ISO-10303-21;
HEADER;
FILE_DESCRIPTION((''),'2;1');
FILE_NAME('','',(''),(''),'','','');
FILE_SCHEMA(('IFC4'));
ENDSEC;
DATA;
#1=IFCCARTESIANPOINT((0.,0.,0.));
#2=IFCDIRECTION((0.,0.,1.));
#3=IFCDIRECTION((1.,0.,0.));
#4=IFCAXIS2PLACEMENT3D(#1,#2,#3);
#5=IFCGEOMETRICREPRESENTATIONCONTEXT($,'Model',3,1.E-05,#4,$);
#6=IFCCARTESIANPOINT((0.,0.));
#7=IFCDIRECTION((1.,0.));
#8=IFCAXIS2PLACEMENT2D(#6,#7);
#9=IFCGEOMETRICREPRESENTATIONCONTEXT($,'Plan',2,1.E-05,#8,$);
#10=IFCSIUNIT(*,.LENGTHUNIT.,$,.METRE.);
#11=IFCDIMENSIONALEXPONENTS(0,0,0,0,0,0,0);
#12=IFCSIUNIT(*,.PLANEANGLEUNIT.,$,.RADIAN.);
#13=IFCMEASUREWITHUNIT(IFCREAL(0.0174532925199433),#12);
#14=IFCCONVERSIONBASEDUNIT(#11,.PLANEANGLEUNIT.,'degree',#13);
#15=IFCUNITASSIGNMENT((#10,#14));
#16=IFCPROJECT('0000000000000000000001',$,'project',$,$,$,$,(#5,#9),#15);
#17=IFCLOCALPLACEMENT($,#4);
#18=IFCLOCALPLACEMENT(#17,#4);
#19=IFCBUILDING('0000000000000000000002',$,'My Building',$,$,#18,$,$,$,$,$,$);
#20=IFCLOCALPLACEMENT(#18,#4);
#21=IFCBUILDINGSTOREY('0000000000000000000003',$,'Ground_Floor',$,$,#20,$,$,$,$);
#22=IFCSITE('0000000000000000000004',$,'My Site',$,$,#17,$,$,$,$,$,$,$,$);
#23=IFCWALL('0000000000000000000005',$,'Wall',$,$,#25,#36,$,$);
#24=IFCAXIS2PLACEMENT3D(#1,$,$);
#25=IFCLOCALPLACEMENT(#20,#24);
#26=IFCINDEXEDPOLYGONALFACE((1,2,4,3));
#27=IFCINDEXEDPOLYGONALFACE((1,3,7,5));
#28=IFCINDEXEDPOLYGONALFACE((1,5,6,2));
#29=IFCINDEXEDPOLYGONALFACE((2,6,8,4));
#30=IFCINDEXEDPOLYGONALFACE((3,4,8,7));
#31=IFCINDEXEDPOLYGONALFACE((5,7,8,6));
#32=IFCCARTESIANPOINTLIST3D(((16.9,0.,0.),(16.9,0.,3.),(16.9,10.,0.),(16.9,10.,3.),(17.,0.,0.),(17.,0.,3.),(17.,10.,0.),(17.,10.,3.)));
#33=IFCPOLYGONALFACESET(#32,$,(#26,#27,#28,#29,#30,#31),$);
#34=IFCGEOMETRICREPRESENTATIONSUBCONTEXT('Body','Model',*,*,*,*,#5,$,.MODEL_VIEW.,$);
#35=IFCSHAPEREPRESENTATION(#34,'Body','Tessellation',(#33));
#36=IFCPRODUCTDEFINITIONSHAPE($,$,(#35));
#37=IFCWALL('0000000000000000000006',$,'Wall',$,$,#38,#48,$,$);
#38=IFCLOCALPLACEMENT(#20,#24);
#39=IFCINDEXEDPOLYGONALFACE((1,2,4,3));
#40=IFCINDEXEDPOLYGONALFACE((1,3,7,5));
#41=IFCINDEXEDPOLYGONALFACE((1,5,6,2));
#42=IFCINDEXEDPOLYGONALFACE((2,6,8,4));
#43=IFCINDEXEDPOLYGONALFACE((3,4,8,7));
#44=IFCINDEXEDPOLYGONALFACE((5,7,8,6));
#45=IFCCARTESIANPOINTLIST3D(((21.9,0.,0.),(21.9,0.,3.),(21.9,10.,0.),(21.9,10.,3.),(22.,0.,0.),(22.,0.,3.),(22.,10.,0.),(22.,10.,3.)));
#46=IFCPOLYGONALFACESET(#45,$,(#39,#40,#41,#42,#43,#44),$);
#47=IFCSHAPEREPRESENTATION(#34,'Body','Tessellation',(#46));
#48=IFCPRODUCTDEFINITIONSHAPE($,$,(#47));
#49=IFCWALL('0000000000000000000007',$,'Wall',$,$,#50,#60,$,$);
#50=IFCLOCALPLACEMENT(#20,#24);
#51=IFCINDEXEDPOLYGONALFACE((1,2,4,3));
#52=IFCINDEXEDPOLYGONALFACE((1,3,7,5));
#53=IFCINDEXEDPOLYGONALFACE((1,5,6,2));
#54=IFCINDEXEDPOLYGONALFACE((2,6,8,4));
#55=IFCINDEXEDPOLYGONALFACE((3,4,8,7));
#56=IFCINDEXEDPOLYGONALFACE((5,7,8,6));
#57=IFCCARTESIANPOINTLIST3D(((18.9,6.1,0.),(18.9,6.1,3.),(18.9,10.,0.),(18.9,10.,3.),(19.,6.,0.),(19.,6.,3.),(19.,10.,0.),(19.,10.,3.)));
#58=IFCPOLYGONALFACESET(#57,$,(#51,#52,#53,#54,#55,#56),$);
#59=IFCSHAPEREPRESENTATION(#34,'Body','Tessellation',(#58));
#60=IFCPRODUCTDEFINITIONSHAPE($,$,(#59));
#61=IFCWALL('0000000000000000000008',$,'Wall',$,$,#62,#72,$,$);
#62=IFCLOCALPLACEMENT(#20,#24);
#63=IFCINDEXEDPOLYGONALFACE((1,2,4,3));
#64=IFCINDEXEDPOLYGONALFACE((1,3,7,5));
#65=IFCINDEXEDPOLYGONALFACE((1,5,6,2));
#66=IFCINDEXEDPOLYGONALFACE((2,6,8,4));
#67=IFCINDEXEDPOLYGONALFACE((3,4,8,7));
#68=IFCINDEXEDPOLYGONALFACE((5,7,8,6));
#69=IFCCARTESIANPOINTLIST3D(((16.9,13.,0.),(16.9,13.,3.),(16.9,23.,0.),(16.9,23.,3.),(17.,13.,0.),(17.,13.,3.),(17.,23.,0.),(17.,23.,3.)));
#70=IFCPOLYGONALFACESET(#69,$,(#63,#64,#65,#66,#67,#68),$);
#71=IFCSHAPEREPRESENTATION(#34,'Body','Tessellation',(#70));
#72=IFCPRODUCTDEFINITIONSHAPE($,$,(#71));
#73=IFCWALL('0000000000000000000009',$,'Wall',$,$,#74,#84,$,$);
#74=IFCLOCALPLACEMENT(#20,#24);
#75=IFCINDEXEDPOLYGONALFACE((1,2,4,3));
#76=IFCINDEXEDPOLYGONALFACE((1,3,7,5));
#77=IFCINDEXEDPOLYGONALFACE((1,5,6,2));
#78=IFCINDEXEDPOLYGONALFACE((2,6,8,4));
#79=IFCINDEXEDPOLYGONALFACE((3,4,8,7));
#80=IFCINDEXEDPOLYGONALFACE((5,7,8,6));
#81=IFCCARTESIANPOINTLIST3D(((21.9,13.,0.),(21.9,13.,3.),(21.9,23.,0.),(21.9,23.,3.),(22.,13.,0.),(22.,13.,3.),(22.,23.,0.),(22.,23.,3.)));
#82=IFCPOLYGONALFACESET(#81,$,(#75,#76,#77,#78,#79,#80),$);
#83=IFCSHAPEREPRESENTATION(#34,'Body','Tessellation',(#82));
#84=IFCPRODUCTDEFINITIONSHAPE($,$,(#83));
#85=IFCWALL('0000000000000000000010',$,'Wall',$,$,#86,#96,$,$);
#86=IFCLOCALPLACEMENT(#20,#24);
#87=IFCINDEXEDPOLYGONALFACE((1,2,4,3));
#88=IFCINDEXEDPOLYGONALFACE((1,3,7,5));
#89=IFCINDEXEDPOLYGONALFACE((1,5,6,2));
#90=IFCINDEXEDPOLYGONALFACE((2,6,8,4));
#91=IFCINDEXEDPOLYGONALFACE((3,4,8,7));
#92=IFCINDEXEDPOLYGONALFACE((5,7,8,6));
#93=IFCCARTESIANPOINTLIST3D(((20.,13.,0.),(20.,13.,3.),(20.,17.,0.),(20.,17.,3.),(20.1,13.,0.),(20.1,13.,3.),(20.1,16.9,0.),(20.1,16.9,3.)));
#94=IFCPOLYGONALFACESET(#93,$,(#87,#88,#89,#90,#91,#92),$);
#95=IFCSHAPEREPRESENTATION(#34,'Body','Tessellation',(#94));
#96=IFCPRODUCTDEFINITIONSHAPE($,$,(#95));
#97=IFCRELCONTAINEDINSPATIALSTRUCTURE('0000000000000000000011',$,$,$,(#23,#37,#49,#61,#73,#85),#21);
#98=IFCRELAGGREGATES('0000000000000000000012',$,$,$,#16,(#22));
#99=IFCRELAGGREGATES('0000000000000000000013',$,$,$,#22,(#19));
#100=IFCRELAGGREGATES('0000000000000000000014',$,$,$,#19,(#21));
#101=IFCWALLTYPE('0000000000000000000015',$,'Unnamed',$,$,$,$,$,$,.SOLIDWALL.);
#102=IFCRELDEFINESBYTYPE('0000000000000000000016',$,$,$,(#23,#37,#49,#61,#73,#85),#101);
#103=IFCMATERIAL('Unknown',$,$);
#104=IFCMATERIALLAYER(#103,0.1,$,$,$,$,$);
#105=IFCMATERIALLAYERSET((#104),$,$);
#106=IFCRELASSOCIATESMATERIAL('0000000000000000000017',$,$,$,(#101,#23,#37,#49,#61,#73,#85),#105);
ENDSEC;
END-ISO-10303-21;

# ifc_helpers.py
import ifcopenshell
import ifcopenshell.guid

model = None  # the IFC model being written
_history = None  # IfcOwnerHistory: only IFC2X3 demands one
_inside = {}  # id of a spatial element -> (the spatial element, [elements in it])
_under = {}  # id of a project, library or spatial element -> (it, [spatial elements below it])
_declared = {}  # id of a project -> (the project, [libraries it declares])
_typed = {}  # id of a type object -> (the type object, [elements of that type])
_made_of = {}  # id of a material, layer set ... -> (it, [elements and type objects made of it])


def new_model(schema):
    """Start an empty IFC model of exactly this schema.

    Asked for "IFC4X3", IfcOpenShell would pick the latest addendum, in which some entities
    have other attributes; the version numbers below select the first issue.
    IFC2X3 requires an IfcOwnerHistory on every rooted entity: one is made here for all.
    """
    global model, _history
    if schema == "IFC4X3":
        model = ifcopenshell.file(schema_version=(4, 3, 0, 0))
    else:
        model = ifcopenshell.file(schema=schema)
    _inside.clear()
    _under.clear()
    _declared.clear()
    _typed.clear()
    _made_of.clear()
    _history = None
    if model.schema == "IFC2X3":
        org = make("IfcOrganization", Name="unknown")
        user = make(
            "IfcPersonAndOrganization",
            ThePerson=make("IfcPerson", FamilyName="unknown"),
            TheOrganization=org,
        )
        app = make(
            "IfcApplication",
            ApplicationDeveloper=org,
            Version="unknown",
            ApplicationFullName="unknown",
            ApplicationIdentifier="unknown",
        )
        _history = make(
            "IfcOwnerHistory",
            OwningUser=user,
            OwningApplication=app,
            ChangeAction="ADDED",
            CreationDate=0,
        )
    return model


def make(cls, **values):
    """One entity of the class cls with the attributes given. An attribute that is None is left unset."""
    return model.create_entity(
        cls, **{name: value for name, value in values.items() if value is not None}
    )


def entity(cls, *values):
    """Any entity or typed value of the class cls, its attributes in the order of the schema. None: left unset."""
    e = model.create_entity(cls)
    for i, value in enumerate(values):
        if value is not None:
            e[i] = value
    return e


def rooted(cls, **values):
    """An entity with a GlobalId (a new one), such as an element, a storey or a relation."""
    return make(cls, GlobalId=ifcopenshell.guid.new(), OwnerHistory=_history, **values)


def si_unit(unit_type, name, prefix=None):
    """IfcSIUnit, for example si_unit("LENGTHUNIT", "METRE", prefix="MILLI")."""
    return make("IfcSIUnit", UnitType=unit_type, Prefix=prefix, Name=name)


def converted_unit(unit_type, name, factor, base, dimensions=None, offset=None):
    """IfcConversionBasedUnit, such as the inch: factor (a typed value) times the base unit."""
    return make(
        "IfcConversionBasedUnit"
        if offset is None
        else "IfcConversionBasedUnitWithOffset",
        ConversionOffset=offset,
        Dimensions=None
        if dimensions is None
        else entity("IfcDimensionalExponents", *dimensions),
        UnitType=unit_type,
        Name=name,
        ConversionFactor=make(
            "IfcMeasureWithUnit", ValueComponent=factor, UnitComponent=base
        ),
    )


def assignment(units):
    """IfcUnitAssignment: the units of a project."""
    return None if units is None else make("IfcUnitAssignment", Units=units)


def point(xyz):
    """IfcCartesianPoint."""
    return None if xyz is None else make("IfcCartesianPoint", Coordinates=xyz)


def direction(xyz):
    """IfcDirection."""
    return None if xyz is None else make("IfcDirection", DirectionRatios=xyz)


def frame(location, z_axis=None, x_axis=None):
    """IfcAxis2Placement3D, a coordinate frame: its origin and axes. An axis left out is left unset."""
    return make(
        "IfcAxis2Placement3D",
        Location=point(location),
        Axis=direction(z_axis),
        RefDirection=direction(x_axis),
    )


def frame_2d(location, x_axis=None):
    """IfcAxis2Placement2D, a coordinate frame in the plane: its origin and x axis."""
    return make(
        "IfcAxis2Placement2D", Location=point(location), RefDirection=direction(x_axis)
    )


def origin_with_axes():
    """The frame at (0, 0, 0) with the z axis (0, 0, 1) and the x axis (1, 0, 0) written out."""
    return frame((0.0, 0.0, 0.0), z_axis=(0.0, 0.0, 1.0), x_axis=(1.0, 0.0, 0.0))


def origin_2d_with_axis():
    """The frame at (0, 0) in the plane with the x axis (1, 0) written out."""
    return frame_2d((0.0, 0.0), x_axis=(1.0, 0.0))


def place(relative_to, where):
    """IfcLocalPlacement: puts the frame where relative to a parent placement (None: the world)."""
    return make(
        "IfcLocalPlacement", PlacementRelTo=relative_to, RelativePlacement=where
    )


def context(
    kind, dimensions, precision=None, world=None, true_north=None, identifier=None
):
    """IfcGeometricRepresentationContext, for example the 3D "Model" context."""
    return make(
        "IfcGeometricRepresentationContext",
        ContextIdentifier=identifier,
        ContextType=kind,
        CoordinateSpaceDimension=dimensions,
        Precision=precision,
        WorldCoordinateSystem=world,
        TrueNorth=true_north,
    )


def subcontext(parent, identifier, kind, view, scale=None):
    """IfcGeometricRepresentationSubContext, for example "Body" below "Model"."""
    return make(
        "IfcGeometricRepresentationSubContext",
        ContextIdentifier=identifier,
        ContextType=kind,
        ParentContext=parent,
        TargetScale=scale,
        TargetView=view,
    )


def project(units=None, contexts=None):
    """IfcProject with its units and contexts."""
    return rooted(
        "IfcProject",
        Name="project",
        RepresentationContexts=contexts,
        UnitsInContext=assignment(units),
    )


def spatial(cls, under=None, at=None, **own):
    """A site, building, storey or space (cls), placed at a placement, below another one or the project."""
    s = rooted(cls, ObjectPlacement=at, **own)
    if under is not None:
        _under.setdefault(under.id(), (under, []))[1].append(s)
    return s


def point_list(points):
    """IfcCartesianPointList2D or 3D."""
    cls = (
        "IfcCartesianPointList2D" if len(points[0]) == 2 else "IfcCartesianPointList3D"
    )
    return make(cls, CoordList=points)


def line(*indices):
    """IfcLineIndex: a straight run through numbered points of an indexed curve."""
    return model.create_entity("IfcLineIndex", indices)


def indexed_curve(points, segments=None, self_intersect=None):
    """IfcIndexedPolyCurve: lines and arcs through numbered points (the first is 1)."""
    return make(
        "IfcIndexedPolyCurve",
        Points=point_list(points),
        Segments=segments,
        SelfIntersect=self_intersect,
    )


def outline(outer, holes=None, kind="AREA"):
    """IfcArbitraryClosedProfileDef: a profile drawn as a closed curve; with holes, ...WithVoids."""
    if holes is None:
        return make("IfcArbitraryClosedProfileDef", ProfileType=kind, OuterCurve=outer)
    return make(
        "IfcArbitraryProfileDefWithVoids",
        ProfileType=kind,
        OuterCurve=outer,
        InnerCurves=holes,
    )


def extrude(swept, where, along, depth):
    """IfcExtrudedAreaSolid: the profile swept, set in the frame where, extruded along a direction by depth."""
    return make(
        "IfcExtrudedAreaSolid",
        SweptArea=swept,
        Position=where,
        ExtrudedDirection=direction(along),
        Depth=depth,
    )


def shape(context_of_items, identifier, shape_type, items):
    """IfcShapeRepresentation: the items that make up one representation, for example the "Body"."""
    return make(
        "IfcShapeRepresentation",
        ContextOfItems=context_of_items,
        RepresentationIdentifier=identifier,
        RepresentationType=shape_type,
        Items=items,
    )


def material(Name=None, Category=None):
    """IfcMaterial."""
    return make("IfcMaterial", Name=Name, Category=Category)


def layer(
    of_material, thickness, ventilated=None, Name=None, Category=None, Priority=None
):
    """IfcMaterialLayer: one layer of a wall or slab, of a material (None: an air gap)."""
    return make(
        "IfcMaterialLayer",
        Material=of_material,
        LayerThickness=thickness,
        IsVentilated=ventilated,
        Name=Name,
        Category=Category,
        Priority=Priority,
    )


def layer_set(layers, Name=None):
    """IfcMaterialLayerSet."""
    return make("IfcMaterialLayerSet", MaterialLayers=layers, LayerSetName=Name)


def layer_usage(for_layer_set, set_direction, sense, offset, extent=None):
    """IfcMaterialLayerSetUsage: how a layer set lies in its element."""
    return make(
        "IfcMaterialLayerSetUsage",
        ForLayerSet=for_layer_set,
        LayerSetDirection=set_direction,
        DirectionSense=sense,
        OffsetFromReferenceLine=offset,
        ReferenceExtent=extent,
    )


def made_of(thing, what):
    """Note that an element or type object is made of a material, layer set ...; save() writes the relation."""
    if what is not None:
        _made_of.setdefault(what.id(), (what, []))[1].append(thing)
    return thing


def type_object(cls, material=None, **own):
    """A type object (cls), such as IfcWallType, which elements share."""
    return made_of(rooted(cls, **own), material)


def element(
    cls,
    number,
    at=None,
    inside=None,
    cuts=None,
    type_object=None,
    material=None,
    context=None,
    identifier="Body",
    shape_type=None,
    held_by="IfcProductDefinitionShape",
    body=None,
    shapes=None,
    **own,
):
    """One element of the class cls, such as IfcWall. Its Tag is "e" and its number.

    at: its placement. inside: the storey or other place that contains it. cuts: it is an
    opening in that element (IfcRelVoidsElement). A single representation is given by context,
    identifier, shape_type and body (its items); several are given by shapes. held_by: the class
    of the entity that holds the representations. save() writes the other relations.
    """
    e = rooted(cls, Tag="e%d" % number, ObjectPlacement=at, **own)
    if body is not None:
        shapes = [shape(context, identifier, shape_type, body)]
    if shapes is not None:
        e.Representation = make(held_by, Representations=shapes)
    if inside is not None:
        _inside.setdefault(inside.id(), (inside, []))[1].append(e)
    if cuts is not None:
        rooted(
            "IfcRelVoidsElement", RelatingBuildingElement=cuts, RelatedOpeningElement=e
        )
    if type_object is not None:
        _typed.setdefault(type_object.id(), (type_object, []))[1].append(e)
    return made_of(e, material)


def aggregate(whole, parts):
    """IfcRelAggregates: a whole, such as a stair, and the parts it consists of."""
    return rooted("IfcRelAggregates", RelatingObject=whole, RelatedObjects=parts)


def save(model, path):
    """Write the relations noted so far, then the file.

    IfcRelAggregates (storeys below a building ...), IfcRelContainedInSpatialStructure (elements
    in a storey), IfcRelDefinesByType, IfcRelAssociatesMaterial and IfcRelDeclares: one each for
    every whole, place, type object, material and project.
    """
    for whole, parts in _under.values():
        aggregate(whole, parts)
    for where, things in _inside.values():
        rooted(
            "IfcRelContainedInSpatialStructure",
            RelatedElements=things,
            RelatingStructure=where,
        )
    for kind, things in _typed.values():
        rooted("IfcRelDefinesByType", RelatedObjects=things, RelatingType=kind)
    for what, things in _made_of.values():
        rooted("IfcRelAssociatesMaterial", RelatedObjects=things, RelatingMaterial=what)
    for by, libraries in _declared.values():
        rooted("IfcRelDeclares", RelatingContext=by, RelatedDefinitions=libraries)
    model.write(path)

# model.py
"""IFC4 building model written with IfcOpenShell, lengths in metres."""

from ifc_helpers import new_model, entity, si_unit, converted_unit, frame, origin_with_axes, origin_2d_with_axis, place, context, subcontext, project, spatial, line, indexed_curve, outline, extrude, material, layer, layer_set, layer_usage, type_object, element, save


model = new_model("IFC4")

# Units and contexts
model_context = context("Model", 3, precision=1e-05, world=origin_with_axes())
plan_context = context("Plan", 2, precision=1e-05, world=origin_2d_with_axis())
body_context_1 = subcontext(model_context, "Body", "Model", "MODEL_VIEW")
ifc_project = project(units=[si_unit("LENGTHUNIT", "METRE"), converted_unit("PLANEANGLEUNIT", "degree", entity("IfcReal", 0.0174532925199433), si_unit("PLANEANGLEUNIT", "RADIAN"), dimensions=[0, 0, 0, 0, 0, 0, 0])], contexts=[model_context, plan_context])

# Site, building, storey
site_placement = place(None, origin_with_axes())
site = spatial("IfcSite", under=ifc_project, at=site_placement, Name="My Site")
building_placement = place(site_placement, origin_with_axes())
building = spatial("IfcBuilding", under=site, at=building_placement, Name="My Building")
storey_placement = place(building_placement, origin_with_axes())
storey = spatial("IfcBuildingStorey", under=building, at=storey_placement, Name="Ground_Floor")

# Walls
ifc_material = material(Name="Unknown")
ifc_layer = layer(ifc_material, 0.1)
ifc_layer_set = layer_set([ifc_layer])
ifc_layer_usage_1 = layer_usage(ifc_layer_set, "AXIS2", "POSITIVE", 0.0)
wall_type = type_object("IfcWallType", Name="Unnamed", PredefinedType="SOLIDWALL", material=ifc_layer_set)
wall_1_placement = place(storey_placement, frame((17.0, 0.0, 0.0), z_axis=(0.0, 0.0, 1.0), x_axis=(0.0, 1.0, 0.0)))
element("IfcWall", 1, at=wall_1_placement, inside=storey, type_object=wall_type, material=ifc_layer_usage_1, Name="Wall", context=body_context_1, shape_type="SweptSolid", body=[
    extrude(outline(indexed_curve([(0.0, 0.0), (0.0, 0.1), (10.0, 0.1), (10.0, 0.0)], segments=[line(1, 2, 3, 4, 1)])), origin_with_axes(), (0.0, 0.0, 1.0), 3.0),
])
ifc_layer_usage_2 = layer_usage(ifc_layer_set, "AXIS2", "POSITIVE", 0.0)
wall_2_placement = place(storey_placement, frame((22.0, 0.0, 0.0), z_axis=(0.0, 0.0, 1.0), x_axis=(0.0, 1.0, 0.0)))
element("IfcWall", 2, at=wall_2_placement, inside=storey, type_object=wall_type, material=ifc_layer_usage_2, Name="Wall", context=body_context_1, shape_type="SweptSolid", body=[
    extrude(outline(indexed_curve([(0.0, 0.0), (0.0, 0.1), (10.0, 0.1), (10.0, 0.0)], segments=[line(1, 2, 3, 4, 1)])), origin_with_axes(), (0.0, 0.0, 1.0), 3.0),
])
ifc_layer_usage_3 = layer_usage(ifc_layer_set, "AXIS2", "POSITIVE", 0.0)
wall_3_placement = place(storey_placement, frame((19.0, 6.0, 0.0), z_axis=(0.0, 0.0, 1.0), x_axis=(0.0, 1.0, 0.0)))
element("IfcWall", 3, at=wall_3_placement, inside=storey, type_object=wall_type, material=ifc_layer_usage_3, Name="Wall", context=body_context_1, shape_type="SweptSolid", body=[
    extrude(outline(indexed_curve([(0.0, 0.0), (0.1, 0.1), (4.0, 0.1), (4.0, 0.0)], segments=[line(1, 2, 3, 4, 1)])), origin_with_axes(), (0.0, 0.0, 1.0), 3.0),
])
ifc_layer_usage_4 = layer_usage(ifc_layer_set, "AXIS2", "POSITIVE", 0.0)
wall_4_placement = place(storey_placement, frame((17.0, 13.0, 0.0), z_axis=(0.0, 0.0, 1.0), x_axis=(0.0, 1.0, 0.0)))
element("IfcWall", 4, at=wall_4_placement, inside=storey, type_object=wall_type, material=ifc_layer_usage_4, Name="Wall", context=body_context_1, shape_type="SweptSolid", body=[
    extrude(outline(indexed_curve([(0.0, 0.0), (0.0, 0.1), (10.0, 0.1), (10.0, 0.0)], segments=[line(1, 2, 3, 4, 1)])), origin_with_axes(), (0.0, 0.0, 1.0), 3.0),
])
ifc_layer_usage_5 = layer_usage(ifc_layer_set, "AXIS2", "POSITIVE", 0.0)
wall_5_placement = place(storey_placement, frame((22.0, 13.0, 0.0), z_axis=(0.0, 0.0, 1.0), x_axis=(0.0, 1.0, 0.0)))
element("IfcWall", 5, at=wall_5_placement, inside=storey, type_object=wall_type, material=ifc_layer_usage_5, Name="Wall", context=body_context_1, shape_type="SweptSolid", body=[
    extrude(outline(indexed_curve([(0.0, 0.0), (0.0, 0.1), (10.0, 0.1), (10.0, 0.0)], segments=[line(1, 2, 3, 4, 1)])), origin_with_axes(), (0.0, 0.0, 1.0), 3.0),
])
ifc_layer_usage_6 = layer_usage(ifc_layer_set, "AXIS2", "POSITIVE", 0.0)
wall_6_placement = place(storey_placement, frame((20.0, 17.0, 0.0), z_axis=(0.0, 0.0, 1.0), x_axis=(0.0, -1.0, 0.0)))
element("IfcWall", 6, at=wall_6_placement, inside=storey, type_object=wall_type, material=ifc_layer_usage_6, Name="Wall", context=body_context_1, shape_type="SweptSolid", body=[
    extrude(outline(indexed_curve([(0.0, 0.0), (0.1, 0.1), (4.0, 0.1), (4.0, 0.0)], segments=[line(1, 2, 3, 4, 1)])), origin_with_axes(), (0.0, 0.0, 1.0), 3.0),
])

save(model, "model.ifc")
